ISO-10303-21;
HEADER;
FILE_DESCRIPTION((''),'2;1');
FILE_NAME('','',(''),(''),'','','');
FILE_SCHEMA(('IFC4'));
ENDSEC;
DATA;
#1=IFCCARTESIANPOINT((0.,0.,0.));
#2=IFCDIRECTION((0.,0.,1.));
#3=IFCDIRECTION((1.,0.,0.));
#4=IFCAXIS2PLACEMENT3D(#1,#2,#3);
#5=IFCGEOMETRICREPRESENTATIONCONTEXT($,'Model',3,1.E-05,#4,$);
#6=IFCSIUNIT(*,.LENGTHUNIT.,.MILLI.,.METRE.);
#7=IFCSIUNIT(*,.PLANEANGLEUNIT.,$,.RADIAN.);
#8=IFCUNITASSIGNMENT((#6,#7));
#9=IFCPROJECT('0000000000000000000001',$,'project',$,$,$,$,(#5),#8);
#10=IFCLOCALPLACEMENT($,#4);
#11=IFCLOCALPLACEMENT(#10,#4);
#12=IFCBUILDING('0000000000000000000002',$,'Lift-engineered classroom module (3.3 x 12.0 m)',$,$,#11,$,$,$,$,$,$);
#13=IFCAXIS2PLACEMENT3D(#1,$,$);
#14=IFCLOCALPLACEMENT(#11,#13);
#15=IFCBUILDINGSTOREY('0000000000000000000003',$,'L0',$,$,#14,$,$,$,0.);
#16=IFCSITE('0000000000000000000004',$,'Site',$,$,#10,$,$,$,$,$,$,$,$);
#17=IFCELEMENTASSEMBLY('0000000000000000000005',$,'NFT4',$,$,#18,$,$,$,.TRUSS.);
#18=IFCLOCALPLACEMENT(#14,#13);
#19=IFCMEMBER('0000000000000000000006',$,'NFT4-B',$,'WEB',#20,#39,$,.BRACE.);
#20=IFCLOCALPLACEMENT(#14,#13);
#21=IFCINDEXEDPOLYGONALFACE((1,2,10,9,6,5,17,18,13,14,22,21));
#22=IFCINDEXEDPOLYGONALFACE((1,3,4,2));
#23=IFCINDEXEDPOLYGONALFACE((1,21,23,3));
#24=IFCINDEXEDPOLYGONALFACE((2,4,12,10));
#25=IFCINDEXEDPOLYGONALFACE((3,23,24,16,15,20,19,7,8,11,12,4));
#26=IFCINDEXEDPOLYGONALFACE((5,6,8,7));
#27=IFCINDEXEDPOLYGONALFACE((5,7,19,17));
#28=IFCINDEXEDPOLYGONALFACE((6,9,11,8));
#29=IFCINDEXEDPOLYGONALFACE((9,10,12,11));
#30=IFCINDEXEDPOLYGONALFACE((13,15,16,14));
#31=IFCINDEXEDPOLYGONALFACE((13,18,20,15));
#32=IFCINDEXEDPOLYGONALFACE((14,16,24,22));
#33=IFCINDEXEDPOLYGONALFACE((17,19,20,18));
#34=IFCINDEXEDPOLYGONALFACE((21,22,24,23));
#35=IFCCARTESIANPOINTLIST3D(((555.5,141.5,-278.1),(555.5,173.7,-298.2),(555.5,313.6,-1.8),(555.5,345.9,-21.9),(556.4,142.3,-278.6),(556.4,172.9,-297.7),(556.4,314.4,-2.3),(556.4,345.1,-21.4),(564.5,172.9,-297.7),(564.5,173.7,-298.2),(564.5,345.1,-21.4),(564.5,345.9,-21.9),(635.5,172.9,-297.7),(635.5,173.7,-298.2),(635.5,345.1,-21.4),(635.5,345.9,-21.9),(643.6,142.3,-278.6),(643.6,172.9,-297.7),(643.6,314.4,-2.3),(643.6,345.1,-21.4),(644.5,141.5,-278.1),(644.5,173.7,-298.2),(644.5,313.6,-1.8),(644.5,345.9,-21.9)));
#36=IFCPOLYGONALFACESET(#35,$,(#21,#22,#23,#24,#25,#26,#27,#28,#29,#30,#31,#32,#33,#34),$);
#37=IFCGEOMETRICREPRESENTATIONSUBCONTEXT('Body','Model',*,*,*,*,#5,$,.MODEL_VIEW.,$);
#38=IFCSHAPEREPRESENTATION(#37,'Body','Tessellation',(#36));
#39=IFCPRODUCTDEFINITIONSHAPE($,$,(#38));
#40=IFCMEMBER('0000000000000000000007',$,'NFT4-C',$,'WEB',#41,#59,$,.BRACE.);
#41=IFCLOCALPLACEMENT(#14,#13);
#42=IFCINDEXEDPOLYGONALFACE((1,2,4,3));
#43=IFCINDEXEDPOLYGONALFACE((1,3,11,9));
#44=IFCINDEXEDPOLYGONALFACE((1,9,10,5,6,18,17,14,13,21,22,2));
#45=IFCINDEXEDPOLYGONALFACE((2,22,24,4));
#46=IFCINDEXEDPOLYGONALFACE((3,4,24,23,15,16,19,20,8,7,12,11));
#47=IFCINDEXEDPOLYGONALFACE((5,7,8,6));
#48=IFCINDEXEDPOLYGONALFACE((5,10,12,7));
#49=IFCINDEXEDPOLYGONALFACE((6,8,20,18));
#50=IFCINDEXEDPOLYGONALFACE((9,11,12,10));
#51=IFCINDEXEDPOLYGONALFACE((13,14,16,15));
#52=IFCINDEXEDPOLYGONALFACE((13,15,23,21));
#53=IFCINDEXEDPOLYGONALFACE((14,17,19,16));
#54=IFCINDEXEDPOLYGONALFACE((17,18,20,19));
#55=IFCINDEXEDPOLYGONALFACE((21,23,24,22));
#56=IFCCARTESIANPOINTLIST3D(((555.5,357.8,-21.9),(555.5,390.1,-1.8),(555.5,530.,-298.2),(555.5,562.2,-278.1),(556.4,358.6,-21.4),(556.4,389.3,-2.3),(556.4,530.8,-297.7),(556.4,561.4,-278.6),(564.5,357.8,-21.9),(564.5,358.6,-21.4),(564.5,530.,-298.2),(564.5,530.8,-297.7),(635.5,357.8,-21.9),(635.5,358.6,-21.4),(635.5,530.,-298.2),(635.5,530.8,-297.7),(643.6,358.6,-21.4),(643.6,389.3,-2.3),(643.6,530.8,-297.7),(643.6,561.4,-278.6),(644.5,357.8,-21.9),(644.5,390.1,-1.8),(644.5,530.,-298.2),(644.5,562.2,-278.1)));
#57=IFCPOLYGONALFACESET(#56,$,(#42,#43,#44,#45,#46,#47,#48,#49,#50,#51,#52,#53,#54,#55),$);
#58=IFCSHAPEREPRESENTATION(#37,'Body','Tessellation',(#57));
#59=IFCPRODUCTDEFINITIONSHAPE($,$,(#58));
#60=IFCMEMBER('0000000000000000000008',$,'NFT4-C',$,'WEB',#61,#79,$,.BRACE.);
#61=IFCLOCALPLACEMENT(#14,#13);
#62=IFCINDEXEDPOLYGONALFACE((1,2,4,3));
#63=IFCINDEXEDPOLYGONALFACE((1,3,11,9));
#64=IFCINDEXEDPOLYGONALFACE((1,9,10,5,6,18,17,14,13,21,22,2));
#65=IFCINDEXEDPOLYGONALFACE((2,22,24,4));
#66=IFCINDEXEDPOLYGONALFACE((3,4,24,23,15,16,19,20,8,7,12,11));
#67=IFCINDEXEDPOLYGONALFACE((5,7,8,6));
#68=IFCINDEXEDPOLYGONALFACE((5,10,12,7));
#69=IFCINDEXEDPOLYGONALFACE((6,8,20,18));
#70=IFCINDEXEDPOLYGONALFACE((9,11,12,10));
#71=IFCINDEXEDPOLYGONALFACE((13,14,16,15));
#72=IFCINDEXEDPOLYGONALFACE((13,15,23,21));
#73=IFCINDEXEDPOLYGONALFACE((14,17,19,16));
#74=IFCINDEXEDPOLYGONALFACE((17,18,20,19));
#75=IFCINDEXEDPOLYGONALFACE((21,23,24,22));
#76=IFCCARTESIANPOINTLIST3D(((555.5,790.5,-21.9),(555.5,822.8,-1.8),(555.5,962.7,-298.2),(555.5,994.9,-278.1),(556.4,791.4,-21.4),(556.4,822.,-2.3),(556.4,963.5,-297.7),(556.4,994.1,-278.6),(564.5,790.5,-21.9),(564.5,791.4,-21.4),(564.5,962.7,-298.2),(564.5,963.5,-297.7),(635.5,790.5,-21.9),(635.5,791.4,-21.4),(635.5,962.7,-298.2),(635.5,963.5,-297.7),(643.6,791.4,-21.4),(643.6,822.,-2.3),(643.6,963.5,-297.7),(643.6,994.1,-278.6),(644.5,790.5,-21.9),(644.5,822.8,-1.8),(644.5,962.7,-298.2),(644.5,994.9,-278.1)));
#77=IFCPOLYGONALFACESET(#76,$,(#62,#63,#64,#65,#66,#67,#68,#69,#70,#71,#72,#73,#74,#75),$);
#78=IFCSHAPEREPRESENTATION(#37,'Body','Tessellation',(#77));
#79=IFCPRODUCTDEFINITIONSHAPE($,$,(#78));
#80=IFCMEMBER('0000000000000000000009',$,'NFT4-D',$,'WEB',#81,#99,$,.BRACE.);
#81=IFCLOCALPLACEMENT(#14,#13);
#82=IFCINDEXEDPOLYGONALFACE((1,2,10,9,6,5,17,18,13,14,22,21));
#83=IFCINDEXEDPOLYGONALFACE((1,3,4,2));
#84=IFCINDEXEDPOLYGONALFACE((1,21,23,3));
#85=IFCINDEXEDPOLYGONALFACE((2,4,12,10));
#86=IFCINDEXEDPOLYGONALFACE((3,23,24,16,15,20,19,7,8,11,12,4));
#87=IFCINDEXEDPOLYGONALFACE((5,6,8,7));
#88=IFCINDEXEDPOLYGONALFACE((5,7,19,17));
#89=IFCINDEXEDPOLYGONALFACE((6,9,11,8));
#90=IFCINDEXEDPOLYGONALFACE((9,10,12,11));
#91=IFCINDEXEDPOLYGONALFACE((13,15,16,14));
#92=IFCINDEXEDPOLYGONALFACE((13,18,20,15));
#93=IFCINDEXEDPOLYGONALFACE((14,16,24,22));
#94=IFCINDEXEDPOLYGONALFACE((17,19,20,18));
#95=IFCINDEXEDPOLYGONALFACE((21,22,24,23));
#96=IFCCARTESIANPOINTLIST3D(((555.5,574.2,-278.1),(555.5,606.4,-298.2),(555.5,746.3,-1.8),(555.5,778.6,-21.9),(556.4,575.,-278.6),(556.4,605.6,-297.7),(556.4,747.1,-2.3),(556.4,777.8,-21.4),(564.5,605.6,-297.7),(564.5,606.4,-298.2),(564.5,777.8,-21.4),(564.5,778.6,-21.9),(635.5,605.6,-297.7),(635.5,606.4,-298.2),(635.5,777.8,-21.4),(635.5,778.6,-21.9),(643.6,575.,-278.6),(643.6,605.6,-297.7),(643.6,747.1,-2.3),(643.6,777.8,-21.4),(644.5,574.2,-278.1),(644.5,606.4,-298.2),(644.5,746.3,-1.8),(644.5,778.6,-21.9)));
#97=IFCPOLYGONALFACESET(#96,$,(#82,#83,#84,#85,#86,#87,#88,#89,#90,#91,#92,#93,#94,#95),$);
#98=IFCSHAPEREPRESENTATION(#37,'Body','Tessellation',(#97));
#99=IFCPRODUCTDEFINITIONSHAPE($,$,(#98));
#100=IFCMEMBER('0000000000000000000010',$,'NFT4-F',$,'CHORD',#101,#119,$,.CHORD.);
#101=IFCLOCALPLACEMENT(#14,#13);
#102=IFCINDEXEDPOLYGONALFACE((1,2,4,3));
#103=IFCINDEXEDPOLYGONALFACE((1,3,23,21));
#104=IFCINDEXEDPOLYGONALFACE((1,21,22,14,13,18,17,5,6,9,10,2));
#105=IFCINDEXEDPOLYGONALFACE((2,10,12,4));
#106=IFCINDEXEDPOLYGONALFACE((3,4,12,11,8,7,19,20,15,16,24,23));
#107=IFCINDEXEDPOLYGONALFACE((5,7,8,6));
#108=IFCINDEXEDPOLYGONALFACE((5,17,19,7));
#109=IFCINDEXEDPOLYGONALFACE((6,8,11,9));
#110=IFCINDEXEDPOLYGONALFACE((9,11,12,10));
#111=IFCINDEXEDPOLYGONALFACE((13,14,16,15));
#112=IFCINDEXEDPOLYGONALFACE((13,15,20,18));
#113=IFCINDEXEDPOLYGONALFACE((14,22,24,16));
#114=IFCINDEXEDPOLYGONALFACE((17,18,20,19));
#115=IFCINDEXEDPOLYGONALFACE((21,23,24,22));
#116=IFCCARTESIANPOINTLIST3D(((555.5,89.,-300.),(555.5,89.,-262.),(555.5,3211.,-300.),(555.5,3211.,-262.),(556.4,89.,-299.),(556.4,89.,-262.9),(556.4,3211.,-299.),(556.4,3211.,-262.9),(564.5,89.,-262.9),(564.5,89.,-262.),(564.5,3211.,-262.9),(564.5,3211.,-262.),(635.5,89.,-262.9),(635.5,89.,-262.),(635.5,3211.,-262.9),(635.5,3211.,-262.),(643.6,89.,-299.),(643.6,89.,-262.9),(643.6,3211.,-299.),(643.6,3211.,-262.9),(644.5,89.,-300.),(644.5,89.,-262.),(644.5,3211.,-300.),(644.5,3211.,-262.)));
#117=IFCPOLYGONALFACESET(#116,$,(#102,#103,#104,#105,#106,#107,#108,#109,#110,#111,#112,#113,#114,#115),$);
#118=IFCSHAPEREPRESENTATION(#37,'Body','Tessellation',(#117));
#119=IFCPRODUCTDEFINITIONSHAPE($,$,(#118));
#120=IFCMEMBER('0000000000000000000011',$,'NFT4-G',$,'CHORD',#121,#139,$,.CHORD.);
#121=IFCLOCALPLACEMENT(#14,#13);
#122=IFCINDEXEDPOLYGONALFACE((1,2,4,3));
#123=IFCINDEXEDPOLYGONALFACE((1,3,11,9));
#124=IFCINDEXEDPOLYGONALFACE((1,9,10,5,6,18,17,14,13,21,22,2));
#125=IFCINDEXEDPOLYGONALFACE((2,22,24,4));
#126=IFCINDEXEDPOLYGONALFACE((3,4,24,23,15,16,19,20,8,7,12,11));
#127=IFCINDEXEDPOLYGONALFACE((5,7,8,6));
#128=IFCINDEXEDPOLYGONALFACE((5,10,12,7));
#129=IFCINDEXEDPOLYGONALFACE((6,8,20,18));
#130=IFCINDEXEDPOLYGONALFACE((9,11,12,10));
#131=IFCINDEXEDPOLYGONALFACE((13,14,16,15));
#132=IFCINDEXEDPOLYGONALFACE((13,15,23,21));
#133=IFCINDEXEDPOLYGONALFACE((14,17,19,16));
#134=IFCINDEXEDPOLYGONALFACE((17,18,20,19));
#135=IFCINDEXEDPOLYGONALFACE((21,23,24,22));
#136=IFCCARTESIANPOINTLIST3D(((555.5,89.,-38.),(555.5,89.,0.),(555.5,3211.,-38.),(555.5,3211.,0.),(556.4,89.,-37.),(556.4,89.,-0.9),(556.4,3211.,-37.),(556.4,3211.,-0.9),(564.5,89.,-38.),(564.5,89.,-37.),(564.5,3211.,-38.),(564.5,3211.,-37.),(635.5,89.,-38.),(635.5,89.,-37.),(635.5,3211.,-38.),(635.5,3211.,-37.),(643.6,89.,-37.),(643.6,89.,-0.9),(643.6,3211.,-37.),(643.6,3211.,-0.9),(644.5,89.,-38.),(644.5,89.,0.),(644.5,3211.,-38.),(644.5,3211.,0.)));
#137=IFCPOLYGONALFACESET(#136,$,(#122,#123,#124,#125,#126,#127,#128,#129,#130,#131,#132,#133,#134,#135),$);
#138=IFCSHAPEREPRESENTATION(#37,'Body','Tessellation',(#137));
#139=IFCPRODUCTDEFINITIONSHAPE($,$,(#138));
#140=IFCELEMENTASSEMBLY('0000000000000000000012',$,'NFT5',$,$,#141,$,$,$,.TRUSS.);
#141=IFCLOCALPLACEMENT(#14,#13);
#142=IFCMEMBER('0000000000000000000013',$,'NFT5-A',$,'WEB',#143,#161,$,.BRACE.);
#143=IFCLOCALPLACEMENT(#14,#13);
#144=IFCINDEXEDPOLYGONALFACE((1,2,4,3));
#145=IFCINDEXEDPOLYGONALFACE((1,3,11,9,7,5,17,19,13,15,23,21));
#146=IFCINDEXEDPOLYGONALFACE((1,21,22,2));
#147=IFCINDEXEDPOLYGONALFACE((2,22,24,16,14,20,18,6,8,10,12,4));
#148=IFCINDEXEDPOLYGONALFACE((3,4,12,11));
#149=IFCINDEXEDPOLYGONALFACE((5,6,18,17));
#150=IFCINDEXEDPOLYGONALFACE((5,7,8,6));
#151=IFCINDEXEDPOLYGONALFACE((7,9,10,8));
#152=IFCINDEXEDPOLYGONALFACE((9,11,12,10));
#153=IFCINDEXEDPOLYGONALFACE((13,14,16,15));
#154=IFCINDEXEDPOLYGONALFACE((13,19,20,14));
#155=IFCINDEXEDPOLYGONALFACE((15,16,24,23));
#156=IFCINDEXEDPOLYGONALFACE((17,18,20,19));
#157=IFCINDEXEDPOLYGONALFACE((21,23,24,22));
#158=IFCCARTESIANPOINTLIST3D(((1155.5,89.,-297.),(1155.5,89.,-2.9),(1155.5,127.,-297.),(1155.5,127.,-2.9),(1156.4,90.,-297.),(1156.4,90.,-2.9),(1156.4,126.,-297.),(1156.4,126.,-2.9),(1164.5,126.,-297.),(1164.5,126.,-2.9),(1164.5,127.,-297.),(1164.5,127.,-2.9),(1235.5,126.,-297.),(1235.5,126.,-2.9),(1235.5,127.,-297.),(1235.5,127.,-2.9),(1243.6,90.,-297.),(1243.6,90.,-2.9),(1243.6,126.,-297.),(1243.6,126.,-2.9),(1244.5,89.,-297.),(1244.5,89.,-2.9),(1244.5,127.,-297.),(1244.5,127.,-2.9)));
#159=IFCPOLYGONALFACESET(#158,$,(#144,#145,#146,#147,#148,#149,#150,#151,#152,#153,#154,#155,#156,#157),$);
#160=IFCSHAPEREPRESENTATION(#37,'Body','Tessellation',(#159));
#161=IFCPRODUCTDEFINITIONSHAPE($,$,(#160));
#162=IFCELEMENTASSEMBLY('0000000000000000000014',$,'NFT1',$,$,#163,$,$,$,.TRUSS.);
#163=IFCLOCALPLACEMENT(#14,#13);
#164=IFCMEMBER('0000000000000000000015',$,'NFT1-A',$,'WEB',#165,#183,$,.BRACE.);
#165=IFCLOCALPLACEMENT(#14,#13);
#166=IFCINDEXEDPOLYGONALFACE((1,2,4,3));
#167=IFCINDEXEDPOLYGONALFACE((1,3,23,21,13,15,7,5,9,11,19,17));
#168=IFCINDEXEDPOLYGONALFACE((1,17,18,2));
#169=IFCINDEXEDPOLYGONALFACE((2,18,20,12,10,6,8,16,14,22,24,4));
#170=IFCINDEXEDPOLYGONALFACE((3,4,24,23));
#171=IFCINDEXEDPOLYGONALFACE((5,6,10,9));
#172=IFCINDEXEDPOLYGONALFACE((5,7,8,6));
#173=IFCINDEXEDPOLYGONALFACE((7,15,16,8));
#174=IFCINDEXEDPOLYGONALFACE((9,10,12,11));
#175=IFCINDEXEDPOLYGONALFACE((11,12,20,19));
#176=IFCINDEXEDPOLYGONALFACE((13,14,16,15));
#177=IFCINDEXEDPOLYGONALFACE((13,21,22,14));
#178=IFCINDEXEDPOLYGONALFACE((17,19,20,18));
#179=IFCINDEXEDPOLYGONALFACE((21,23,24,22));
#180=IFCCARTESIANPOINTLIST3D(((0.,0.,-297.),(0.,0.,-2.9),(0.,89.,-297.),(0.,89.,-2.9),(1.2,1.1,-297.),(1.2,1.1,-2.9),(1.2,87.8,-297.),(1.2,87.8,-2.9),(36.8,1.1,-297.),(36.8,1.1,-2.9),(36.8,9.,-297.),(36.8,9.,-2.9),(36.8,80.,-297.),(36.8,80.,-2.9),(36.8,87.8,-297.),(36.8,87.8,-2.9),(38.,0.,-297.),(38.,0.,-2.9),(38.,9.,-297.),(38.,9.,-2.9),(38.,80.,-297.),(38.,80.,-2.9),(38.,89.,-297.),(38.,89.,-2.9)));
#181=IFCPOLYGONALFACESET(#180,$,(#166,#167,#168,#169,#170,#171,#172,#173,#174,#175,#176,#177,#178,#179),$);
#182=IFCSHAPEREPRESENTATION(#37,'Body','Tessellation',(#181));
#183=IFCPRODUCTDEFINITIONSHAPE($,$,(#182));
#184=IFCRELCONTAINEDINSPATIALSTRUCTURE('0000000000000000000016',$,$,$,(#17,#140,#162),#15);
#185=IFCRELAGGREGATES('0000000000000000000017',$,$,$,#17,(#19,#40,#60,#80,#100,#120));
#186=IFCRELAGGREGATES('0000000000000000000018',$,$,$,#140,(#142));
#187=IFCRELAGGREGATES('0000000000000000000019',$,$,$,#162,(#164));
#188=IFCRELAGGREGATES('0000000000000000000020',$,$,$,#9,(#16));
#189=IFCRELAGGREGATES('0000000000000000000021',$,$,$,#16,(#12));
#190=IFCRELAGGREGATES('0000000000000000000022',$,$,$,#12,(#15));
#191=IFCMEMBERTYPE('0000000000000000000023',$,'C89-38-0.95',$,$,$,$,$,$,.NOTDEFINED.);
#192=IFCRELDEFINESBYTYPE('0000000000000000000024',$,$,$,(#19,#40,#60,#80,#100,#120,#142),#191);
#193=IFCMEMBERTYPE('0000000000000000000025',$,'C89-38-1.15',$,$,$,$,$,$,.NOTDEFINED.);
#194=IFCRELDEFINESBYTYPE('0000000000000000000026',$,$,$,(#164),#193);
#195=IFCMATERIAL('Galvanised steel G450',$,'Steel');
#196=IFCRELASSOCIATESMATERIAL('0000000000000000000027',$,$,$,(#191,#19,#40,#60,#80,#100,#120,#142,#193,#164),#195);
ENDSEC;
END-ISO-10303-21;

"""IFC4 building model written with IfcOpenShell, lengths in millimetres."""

from ifc_helpers import new_model, si_unit, frame, origin, origin_with_axes, origin_2d, place, context, subcontext, project, spatial, c_section, extrude, material, material_profile, profile_set, profile_usage, type_object, element, aggregate, save


model = new_model("IFC4")

# Units and contexts
model_context = context("Model", 3, precision=1e-05, world=origin_with_axes())
body_context = subcontext(model_context, "Body", "Model", "MODEL_VIEW")
ifc_project = project(units=[si_unit("LENGTHUNIT", "METRE", prefix="MILLI"), si_unit("PLANEANGLEUNIT", "RADIAN")], contexts=[model_context])

# Site, building, storey
site_placement = place(None, origin_with_axes())
site = spatial("IfcSite", under=ifc_project, at=site_placement, Name="Site")
building_placement = place(site_placement, origin_with_axes())
building = spatial("IfcBuilding", under=site, at=building_placement, Name="Lift-engineered classroom module (3.3 x 12.0 m)")
storey_placement = place(building_placement, origin())
storey = spatial("IfcBuildingStorey", under=building, at=storey_placement, Name="L0", Elevation=0.0)

# Element assembly, members
ifc_material = material(Name="Galvanised steel G450", Category="Steel")
ifc_material_profile_1 = material_profile(ifc_material, c_section(Depth=89.0, Width=38.0, WallThickness=0.9, Girth=9.0, at=origin_2d()), Name="C89-38-0.95")
ifc_profile_set_1 = profile_set([ifc_material_profile_1], Name="C89-38-0.95")
ifc_profile_usage_1 = profile_usage(ifc_profile_set_1)
member_type_1 = type_object("IfcMemberType", Name="C89-38-0.95", PredefinedType="NOTDEFINED", material=ifc_profile_set_1)
assembly_1_placement = place(storey_placement, frame((600.0, 89.0, -300.0)))
assembly_1 = element("IfcElementAssembly", 1, at=assembly_1_placement, inside=storey, Name="NFT4", PredefinedType="TRUSS")
member_1_placement = place(assembly_1_placement, frame((0.0, 68.6, 11.8), z_axis=(0.0, 0.528797, 0.848748), x_axis=(0.0, 0.848748, -0.528797)))
member_1 = element("IfcMember", 2, at=member_1_placement, type_object=member_type_1, material=ifc_profile_usage_1, Name="NFT4-B", ObjectType="WEB", PredefinedType="BRACE", context=body_context, shape_type="SweptSolid", body=[
    extrude(c_section(Depth=89.0, Width=38.0, WallThickness=0.9, Girth=9.0, at=origin_2d()), origin(), (0.0, 0.0, 1.0), 325.6),
])
member_2_placement = place(assembly_1_placement, frame((0.0, 457.1, 11.8), z_axis=(0.0, -0.528797, 0.848748), x_axis=(0.0, -0.848748, -0.528797)))
member_2 = element("IfcMember", 3, at=member_2_placement, type_object=member_type_1, material=ifc_profile_usage_1, Name="NFT4-C", ObjectType="WEB", PredefinedType="BRACE", context=body_context, shape_type="SweptSolid", body=[
    extrude(c_section(Depth=89.0, Width=38.0, WallThickness=0.9, Girth=9.0, at=origin_2d()), origin(), (0.0, 0.0, 1.0), 325.6),
])
member_3_placement = place(assembly_1_placement, frame((0.0, 889.8, 11.8), z_axis=(0.0, -0.528797, 0.848748), x_axis=(0.0, -0.848748, -0.528797)))
member_3 = element("IfcMember", 4, at=member_3_placement, type_object=member_type_1, material=ifc_profile_usage_1, Name="NFT4-C", ObjectType="WEB", PredefinedType="BRACE", context=body_context, shape_type="SweptSolid", body=[
    extrude(c_section(Depth=89.0, Width=38.0, WallThickness=0.9, Girth=9.0, at=origin_2d()), origin(), (0.0, 0.0, 1.0), 325.6),
])
member_4_placement = place(assembly_1_placement, frame((0.0, 501.3, 11.8), z_axis=(0.0, 0.528775, 0.848762), x_axis=(0.0, 0.848762, -0.528775)))
member_4 = element("IfcMember", 5, at=member_4_placement, type_object=member_type_1, material=ifc_profile_usage_1, Name="NFT4-D", ObjectType="WEB", PredefinedType="BRACE", context=body_context, shape_type="SweptSolid", body=[
    extrude(c_section(Depth=89.0, Width=38.0, WallThickness=0.9, Girth=9.0, at=origin_2d()), origin(), (0.0, 0.0, 1.0), 325.6),
])
member_5_placement = place(assembly_1_placement, frame((0.0, 0.0, 19.0), z_axis=(0.0, 1.0, 0.0), x_axis=(0.0, 0.0, 1.0)))
member_5 = element("IfcMember", 6, at=member_5_placement, type_object=member_type_1, material=ifc_profile_usage_1, Name="NFT4-F", ObjectType="CHORD", PredefinedType="CHORD", context=body_context, shape_type="SweptSolid", body=[
    extrude(c_section(Depth=89.0, Width=38.0, WallThickness=0.9, Girth=9.0, at=origin_2d()), origin(), (0.0, 0.0, 1.0), 3122.0),
])
member_6_placement = place(assembly_1_placement, frame((0.0, 0.0, 281.0), z_axis=(0.0, 1.0, 0.0), x_axis=(0.0, 0.0, -1.0)))
member_6 = element("IfcMember", 7, at=member_6_placement, type_object=member_type_1, material=ifc_profile_usage_1, Name="NFT4-G", ObjectType="CHORD", PredefinedType="CHORD", context=body_context, shape_type="SweptSolid", body=[
    extrude(c_section(Depth=89.0, Width=38.0, WallThickness=0.9, Girth=9.0, at=origin_2d()), origin(), (0.0, 0.0, 1.0), 3122.0),
])
aggregate(assembly_1, [member_1, member_2, member_3, member_4, member_5, member_6])

# Element assembly, member
assembly_2_placement = place(storey_placement, frame((1200.0, 89.0, -300.0)))
assembly_2 = element("IfcElementAssembly", 8, at=assembly_2_placement, inside=storey, Name="NFT5", PredefinedType="TRUSS")
member_7_placement = place(assembly_2_placement, frame((0.0, 19.0, 2.9), z_axis=(0.0, 0.0, 1.0), x_axis=(0.0, 1.0, 0.0)))
member_7 = element("IfcMember", 9, at=member_7_placement, type_object=member_type_1, material=ifc_profile_usage_1, Name="NFT5-A", ObjectType="WEB", PredefinedType="BRACE", context=body_context, shape_type="SweptSolid", body=[
    extrude(c_section(Depth=89.0, Width=38.0, WallThickness=0.9, Girth=9.0, at=origin_2d()), origin(), (0.0, 0.0, 1.0), 294.1),
])
aggregate(assembly_2, [member_7])

# Element assembly, member
assembly_3_placement = place(storey_placement, frame((0.0, 44.5, -300.0)))
assembly_3 = element("IfcElementAssembly", 10, at=assembly_3_placement, inside=storey, Name="NFT1", PredefinedType="TRUSS")
ifc_material_profile_2 = material_profile(ifc_material, c_section(Depth=89.0, Width=38.0, WallThickness=1.1, Girth=9.0, at=origin_2d()), Name="C89-38-1.15")
ifc_profile_set_2 = profile_set([ifc_material_profile_2], Name="C89-38-1.15")
ifc_profile_usage_2 = profile_usage(ifc_profile_set_2)
member_type_2 = type_object("IfcMemberType", Name="C89-38-1.15", PredefinedType="NOTDEFINED", material=ifc_profile_set_2)
member_8_placement = place(assembly_3_placement, frame((19.0, 0.0, 2.9), z_axis=(0.0, 0.0, 1.0), x_axis=(1.0, 0.0, 0.0)))
member_8 = element("IfcMember", 11, at=member_8_placement, type_object=member_type_2, material=ifc_profile_usage_2, Name="NFT1-A", ObjectType="WEB", PredefinedType="BRACE", context=body_context, shape_type="SweptSolid", body=[
    extrude(c_section(Depth=89.0, Width=38.0, WallThickness=1.1, Girth=9.0, at=origin_2d()), origin(), (0.0, 0.0, 1.0), 294.1),
])
aggregate(assembly_3, [member_8])

save(model, "model.ifc")
